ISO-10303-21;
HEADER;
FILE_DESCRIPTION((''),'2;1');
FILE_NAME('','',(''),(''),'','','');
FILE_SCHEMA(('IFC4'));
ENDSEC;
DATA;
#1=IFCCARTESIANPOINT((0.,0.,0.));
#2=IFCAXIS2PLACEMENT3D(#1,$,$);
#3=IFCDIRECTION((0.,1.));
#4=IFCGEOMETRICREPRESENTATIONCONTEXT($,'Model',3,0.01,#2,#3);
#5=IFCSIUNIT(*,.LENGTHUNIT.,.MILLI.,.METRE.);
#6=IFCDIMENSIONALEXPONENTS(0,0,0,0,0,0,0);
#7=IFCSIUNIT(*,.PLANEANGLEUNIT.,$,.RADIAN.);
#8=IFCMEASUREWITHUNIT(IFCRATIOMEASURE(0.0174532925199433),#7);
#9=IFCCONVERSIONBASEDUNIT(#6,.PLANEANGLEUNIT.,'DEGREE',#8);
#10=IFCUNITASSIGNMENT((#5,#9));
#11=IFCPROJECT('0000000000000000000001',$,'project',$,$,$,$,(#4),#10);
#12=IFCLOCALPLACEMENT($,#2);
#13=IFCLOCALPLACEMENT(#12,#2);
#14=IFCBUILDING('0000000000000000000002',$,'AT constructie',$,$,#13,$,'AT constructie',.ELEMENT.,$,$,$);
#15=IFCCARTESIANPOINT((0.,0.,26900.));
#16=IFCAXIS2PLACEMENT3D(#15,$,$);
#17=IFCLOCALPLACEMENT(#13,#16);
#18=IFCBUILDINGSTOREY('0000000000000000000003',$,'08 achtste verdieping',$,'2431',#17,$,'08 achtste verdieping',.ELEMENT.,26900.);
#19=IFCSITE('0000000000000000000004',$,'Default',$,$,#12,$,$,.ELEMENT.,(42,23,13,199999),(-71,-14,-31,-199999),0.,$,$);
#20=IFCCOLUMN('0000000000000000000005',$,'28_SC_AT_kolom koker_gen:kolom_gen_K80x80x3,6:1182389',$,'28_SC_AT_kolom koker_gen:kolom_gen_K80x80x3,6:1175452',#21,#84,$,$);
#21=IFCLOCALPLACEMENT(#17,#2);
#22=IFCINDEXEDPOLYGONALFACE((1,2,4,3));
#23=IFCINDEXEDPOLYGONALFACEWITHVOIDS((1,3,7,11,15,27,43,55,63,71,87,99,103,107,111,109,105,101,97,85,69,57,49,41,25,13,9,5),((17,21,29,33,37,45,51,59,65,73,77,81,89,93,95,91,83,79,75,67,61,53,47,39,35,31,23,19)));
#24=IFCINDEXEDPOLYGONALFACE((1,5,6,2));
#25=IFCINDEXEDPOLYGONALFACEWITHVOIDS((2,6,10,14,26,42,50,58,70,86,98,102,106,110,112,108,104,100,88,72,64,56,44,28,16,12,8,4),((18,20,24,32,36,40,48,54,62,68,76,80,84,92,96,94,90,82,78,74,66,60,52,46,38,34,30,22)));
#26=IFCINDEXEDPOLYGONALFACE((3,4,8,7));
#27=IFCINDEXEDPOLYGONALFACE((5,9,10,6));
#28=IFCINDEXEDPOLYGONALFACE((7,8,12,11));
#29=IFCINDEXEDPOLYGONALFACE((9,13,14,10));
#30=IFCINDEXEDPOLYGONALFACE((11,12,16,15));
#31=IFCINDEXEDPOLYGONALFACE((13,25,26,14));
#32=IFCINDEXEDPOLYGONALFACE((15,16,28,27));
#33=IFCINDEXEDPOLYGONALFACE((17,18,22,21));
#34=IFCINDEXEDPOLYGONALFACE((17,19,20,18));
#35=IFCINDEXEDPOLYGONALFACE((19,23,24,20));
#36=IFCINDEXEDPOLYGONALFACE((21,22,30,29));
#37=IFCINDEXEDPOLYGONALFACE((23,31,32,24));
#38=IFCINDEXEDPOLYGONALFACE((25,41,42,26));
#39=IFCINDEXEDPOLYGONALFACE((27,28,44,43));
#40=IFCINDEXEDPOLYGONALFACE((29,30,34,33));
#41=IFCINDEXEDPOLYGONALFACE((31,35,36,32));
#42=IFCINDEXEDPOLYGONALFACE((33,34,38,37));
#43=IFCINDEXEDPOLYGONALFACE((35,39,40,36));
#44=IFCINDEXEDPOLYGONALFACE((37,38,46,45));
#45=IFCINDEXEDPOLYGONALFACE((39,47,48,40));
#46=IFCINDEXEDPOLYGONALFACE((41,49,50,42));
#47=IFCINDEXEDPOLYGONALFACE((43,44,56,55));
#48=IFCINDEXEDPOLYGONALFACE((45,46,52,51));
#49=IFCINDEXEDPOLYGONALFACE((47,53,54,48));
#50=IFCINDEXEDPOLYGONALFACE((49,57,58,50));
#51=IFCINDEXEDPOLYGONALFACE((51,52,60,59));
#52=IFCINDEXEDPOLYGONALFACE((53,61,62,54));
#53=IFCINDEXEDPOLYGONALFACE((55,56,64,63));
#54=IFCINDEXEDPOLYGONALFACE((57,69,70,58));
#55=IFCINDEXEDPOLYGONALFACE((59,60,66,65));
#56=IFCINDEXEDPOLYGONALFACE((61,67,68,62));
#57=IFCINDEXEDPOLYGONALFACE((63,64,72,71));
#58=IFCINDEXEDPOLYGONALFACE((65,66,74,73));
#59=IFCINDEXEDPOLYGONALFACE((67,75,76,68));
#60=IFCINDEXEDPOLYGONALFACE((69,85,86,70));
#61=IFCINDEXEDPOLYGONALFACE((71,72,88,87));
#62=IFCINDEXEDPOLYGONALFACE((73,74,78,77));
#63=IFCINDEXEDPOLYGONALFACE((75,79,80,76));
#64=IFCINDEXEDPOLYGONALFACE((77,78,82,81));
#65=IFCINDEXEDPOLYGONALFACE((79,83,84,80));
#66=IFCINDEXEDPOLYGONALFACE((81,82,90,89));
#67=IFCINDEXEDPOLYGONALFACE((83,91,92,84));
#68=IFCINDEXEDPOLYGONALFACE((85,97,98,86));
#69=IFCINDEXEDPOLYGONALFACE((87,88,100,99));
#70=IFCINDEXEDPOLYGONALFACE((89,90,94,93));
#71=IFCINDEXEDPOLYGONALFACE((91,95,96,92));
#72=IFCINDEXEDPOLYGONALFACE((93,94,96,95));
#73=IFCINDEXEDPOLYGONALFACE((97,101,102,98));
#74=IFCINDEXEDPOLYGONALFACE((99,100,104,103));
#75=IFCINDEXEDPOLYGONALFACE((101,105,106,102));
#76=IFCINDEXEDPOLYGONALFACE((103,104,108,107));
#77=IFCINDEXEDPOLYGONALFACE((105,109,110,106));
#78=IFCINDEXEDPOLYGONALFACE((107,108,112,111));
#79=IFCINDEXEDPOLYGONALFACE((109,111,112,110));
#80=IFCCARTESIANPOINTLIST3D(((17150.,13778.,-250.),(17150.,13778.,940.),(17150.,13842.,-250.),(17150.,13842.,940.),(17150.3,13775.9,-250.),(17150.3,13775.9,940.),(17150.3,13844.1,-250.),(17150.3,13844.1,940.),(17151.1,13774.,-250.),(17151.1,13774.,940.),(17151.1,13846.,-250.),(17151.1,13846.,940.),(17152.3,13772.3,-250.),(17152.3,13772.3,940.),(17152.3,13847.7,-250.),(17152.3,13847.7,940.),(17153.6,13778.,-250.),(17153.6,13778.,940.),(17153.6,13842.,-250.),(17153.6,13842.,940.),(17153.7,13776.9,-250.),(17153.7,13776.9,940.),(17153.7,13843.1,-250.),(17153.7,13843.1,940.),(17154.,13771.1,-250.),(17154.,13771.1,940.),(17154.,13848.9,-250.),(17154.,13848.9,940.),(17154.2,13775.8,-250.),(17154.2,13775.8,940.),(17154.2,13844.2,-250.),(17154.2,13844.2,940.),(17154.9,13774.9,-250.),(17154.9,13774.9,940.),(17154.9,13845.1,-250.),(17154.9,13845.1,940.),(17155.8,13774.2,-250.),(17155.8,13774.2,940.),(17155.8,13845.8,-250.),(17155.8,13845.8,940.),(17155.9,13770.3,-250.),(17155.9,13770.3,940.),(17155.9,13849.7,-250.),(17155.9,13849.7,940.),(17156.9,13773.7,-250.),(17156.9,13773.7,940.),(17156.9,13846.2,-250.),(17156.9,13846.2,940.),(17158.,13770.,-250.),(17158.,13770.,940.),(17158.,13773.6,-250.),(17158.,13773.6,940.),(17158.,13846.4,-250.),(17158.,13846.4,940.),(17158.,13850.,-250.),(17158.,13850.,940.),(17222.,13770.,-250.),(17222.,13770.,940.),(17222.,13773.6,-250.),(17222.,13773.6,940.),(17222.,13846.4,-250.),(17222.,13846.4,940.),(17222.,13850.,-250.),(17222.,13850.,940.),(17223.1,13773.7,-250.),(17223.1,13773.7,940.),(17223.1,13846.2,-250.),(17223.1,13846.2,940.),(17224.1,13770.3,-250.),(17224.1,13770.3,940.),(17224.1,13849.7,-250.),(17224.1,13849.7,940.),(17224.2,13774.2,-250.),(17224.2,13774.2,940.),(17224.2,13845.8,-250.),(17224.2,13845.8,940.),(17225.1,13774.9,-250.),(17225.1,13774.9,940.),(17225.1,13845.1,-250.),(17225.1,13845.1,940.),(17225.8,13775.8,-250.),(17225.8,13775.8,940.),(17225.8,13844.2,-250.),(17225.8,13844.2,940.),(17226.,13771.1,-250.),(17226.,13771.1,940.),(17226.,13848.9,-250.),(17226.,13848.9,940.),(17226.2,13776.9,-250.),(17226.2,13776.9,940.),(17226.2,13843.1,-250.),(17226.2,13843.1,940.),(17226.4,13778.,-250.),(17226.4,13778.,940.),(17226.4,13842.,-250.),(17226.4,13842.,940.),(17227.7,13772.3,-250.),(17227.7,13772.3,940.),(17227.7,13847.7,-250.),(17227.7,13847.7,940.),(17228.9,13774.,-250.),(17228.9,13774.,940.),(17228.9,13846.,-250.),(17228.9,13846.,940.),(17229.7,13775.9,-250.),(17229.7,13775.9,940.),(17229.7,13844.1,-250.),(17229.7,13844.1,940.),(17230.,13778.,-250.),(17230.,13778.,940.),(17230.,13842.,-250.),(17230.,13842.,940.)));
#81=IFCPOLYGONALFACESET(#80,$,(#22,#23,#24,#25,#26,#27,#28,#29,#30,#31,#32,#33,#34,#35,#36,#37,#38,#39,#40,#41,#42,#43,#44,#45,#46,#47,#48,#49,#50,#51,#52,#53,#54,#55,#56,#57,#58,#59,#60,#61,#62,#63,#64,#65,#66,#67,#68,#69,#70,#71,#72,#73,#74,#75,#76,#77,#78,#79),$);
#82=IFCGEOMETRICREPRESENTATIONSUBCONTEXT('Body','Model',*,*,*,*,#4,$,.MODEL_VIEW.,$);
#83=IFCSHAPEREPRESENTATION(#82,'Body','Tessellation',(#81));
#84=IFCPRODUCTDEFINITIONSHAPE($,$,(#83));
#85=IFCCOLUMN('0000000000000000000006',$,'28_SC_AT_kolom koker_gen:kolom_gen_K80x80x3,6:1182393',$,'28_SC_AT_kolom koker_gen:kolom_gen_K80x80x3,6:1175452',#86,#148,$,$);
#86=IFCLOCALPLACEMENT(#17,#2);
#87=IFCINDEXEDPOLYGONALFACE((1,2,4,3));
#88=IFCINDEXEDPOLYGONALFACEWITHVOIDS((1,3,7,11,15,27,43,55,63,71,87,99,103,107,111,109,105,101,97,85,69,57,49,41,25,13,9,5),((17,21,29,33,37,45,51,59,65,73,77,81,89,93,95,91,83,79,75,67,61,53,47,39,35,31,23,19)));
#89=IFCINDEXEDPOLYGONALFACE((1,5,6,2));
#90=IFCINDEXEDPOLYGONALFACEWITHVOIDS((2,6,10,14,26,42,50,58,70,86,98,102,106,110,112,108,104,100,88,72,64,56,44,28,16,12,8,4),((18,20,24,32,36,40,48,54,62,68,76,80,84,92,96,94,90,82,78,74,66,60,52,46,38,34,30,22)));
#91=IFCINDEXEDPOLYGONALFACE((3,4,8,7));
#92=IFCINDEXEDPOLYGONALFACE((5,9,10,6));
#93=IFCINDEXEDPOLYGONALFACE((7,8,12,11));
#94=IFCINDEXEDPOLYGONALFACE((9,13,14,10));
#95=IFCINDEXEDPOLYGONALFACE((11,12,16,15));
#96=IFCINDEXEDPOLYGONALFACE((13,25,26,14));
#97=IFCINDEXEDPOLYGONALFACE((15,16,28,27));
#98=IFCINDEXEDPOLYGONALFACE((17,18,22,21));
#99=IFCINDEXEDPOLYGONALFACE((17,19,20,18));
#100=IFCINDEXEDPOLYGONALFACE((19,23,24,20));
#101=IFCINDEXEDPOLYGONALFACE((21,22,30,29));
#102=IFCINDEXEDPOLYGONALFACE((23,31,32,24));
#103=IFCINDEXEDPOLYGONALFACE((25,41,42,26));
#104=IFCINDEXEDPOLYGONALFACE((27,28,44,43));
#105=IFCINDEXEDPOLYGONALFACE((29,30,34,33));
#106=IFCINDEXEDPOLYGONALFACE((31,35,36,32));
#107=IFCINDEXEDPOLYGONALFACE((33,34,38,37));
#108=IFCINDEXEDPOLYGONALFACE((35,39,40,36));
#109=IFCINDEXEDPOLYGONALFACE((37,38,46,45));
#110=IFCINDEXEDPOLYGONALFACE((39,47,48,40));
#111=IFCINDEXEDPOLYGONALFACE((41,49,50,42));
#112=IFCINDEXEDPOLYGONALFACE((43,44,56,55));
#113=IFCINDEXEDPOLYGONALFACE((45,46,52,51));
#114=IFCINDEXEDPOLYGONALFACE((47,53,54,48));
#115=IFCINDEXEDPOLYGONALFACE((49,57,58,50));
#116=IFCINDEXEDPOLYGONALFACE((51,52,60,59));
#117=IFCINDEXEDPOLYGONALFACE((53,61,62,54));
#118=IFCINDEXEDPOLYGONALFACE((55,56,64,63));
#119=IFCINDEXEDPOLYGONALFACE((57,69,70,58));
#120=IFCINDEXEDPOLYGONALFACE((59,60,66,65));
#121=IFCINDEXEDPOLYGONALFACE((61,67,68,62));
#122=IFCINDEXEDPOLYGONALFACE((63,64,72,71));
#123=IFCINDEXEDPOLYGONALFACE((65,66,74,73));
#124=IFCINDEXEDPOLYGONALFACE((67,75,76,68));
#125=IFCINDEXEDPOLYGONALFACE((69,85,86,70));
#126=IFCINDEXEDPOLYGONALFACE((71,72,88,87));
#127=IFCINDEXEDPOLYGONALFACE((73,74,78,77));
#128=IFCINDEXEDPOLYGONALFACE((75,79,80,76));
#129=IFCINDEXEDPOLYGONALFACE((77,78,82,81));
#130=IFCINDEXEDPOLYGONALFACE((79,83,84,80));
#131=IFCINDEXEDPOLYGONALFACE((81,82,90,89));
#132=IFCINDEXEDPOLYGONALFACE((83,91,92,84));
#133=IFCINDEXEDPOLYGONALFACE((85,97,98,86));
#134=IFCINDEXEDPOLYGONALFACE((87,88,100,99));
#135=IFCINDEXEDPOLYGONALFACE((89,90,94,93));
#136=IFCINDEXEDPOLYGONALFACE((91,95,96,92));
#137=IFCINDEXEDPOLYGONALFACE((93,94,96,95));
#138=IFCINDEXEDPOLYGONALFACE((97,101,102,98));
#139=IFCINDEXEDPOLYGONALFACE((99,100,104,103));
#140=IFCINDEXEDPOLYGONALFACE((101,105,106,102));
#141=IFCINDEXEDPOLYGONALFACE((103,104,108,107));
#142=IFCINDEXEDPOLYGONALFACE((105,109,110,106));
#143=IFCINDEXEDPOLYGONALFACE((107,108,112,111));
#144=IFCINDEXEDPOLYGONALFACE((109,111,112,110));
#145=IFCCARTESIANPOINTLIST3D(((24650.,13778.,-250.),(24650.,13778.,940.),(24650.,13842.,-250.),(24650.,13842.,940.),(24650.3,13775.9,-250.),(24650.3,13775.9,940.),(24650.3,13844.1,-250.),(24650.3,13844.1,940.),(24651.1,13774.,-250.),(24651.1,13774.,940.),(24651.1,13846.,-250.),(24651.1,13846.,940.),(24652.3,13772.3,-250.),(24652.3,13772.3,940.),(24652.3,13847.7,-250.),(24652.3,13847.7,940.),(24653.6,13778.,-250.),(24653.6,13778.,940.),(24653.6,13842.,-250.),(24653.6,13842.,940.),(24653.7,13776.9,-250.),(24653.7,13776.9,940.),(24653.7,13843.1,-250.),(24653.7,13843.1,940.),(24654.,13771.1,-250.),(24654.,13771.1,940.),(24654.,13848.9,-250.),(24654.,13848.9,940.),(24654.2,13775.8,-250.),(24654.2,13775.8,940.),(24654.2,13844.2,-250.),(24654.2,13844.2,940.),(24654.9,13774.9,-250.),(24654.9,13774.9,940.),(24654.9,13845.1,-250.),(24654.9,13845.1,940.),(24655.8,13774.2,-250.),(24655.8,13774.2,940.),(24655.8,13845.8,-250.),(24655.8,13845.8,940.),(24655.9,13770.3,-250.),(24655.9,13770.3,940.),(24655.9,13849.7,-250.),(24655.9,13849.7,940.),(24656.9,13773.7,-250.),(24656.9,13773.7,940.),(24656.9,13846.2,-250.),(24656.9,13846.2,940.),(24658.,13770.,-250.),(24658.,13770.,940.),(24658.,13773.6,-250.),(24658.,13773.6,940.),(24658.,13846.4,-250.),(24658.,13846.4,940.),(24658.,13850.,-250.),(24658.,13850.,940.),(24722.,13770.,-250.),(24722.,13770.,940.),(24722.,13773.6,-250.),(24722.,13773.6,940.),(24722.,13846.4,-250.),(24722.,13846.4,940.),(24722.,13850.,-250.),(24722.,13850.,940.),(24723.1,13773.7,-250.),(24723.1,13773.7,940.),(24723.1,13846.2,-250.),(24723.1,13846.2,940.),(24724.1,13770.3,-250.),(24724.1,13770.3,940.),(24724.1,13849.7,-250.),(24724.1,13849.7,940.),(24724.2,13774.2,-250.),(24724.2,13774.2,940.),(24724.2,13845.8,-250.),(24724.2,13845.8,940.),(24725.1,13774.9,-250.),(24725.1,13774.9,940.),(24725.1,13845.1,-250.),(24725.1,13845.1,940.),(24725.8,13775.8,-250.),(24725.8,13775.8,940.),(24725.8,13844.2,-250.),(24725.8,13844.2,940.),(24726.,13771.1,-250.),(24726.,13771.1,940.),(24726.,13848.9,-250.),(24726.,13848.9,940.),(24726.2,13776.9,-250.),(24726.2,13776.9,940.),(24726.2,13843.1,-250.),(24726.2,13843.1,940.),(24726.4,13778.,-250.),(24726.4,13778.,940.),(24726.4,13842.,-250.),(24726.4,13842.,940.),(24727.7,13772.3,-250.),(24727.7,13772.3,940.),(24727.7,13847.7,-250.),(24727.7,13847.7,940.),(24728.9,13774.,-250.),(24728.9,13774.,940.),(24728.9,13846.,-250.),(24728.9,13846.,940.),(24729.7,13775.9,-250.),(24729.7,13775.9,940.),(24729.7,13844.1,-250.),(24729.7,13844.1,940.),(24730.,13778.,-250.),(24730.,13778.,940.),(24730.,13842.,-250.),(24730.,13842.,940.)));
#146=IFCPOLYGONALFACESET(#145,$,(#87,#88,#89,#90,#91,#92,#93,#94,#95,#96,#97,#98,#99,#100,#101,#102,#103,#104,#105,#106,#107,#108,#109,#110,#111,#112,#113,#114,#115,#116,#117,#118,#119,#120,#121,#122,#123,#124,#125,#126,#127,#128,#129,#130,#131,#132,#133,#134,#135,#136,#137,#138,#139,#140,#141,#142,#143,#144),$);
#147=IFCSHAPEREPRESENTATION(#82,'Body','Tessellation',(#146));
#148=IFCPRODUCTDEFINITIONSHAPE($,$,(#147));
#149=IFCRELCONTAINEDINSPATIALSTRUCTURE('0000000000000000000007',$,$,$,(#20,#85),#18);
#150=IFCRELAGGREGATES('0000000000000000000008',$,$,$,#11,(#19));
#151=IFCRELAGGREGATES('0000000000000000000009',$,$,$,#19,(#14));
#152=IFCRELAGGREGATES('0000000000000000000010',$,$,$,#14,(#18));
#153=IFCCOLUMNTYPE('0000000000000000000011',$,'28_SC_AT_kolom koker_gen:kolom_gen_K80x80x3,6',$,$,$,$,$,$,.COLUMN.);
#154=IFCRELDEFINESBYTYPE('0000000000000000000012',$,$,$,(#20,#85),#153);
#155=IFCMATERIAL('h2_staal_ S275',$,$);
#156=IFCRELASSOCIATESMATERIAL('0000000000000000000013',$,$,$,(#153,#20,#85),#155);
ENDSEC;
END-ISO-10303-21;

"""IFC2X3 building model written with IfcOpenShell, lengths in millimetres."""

from ifc_helpers import new_model, entity, si_unit, converted_unit, direction, frame, frame_2d, origin, place, context, subcontext, project, spatial, polyline, circle_curve, parameter, trimmed, segment, composite_curve, outline, extrude, source, transform, mapped, material, type_object, type_shapes, element, save


model = new_model("IFC2X3")

# Units and contexts
model_context = context("Model", 3, precision=0.01, world=origin(), true_north=direction((0.0, 1.0)))
body_context = subcontext(model_context, "Body", "Model", "MODEL_VIEW")
ifc_project = project(units=[si_unit("LENGTHUNIT", "METRE", prefix="MILLI"), converted_unit("PLANEANGLEUNIT", "DEGREE", entity("IfcRatioMeasure", 0.0174532925199433), si_unit("PLANEANGLEUNIT", "RADIAN"), dimensions=[0, 0, 0, 0, 0, 0, 0])], contexts=[model_context])

# Site, building, storey
site_placement = place(None, origin())
site = spatial("IfcSite", under=ifc_project, at=site_placement, Name="Default", CompositionType="ELEMENT", RefLatitude=(42, 23, 13, 199999), RefLongitude=(-71, -14, -31, -199999), RefElevation=0.0)
building_placement = place(site_placement, origin())
building = spatial("IfcBuilding", under=site, at=building_placement, Name="AT constructie", LongName="AT constructie", CompositionType="ELEMENT")
storey_placement = place(building_placement, frame((0.0, 0.0, 26900.0)))
storey = spatial("IfcBuildingStorey", under=building, at=storey_placement, Name="08 achtste verdieping", ObjectType="2431", LongName="08 achtste verdieping", CompositionType="ELEMENT", Elevation=26900.0)

# Columns
ifc_material_1 = material(Name="h2_staal_ S275")
column_type_1 = type_object("IfcColumnType", Name="28_SC_AT_kolom koker_gen:kolom_gen_K80x80x3,6", PredefinedType="COLUMN", material=ifc_material_1)
shared_shape_1 = source(origin(), body_context, "Body", "SweptSolid", [
    extrude(outline(composite_curve([segment(trimmed(circle_curve(frame_2d((32.0, 32.0), x_axis=(1.0, 0.0)), 8.0), [parameter(360.0)], [parameter(90.0)], True, "PARAMETER"), True, "CONTINUOUS"), segment(polyline([(32.0, 40.0), (-32.0, 40.0)]), True, "CONTINUOUS"), segment(trimmed(circle_curve(frame_2d((-32.0, 32.0), x_axis=(1.0, 0.0)), 8.0), [parameter(90.0)], [parameter(180.0)], True, "PARAMETER"), True, "CONTINUOUS"), segment(polyline([(-40.0, 32.0), (-40.0, -32.0)]), True, "CONTINUOUS"), segment(trimmed(circle_curve(frame_2d((-32.0, -32.0), x_axis=(1.0, 0.0)), 8.0), [parameter(180.0)], [parameter(270.0)], True, "PARAMETER"), True, "CONTINUOUS"), segment(polyline([(-32.0, -40.0), (32.0, -40.0)]), True, "CONTINUOUS"), segment(trimmed(circle_curve(frame_2d((32.0, -32.0), x_axis=(1.0, 0.0)), 8.0), [parameter(270.0)], [parameter(0.0)], True, "PARAMETER"), True, "CONTINUOUS"), segment(polyline([(40.0, -32.0), (40.0, 32.0)]), True, "CONTINUOUS")], self_intersect=False), holes=[composite_curve([segment(polyline([(-32.0, 36.4), (32.0, 36.4)]), True, "CONTINUOUS"), segment(trimmed(circle_curve(frame_2d((32.0, 32.0), x_axis=(1.0, 0.0)), 4.4), [parameter(360.0)], [parameter(90.0)], True, "PARAMETER"), False, "CONTINUOUS"), segment(polyline([(36.4, 32.0), (36.4, -32.0)]), True, "CONTINUOUS"), segment(trimmed(circle_curve(frame_2d((32.0, -32.0), x_axis=(1.0, 0.0)), 4.4), [parameter(270.0)], [parameter(360.0)], True, "PARAMETER"), False, "CONTINUOUS"), segment(polyline([(32.0, -36.4), (-32.0, -36.4)]), True, "CONTINUOUS"), segment(trimmed(circle_curve(frame_2d((-32.0, -32.0), x_axis=(1.0, 0.0)), 4.4), [parameter(180.0)], [parameter(270.0)], True, "PARAMETER"), False, "CONTINUOUS"), segment(polyline([(-36.4, -32.0), (-36.4, 32.0)]), True, "CONTINUOUS"), segment(trimmed(circle_curve(frame_2d((-32.0, 32.0), x_axis=(1.0, 0.0)), 4.4), [parameter(90.0)], [parameter(180.0)], True, "PARAMETER"), False, "CONTINUOUS")], self_intersect=False)]), frame((0.0, 0.0, 26650.0), z_axis=(0.0, 0.0, 1.0), x_axis=(-1.0, 0.0, 0.0)), (0.0, 0.0, 1.0), 1190.0),
])
type_shapes(column_type_1, [shared_shape_1])
for number, where, name in (
    (1, (17190.0, 13810.0, -26900.0), "28_SC_AT_kolom koker_gen:kolom_gen_K80x80x3,6:1182389"),
    (2, (24690.0, 13810.0, -26900.0), "28_SC_AT_kolom koker_gen:kolom_gen_K80x80x3,6:1182393"),
):
    element("IfcColumn", number, at=place(storey_placement, frame(where)), inside=storey, type_object=column_type_1, material=ifc_material_1, Name=name, ObjectType="28_SC_AT_kolom koker_gen:kolom_gen_K80x80x3,6:1175452", context=body_context, shape_type="MappedRepresentation", body=[
        mapped(shared_shape_1, transform((0.0, 0.0, 0.0), scale=1.0)),
    ])

save(model, "model.ifc")
